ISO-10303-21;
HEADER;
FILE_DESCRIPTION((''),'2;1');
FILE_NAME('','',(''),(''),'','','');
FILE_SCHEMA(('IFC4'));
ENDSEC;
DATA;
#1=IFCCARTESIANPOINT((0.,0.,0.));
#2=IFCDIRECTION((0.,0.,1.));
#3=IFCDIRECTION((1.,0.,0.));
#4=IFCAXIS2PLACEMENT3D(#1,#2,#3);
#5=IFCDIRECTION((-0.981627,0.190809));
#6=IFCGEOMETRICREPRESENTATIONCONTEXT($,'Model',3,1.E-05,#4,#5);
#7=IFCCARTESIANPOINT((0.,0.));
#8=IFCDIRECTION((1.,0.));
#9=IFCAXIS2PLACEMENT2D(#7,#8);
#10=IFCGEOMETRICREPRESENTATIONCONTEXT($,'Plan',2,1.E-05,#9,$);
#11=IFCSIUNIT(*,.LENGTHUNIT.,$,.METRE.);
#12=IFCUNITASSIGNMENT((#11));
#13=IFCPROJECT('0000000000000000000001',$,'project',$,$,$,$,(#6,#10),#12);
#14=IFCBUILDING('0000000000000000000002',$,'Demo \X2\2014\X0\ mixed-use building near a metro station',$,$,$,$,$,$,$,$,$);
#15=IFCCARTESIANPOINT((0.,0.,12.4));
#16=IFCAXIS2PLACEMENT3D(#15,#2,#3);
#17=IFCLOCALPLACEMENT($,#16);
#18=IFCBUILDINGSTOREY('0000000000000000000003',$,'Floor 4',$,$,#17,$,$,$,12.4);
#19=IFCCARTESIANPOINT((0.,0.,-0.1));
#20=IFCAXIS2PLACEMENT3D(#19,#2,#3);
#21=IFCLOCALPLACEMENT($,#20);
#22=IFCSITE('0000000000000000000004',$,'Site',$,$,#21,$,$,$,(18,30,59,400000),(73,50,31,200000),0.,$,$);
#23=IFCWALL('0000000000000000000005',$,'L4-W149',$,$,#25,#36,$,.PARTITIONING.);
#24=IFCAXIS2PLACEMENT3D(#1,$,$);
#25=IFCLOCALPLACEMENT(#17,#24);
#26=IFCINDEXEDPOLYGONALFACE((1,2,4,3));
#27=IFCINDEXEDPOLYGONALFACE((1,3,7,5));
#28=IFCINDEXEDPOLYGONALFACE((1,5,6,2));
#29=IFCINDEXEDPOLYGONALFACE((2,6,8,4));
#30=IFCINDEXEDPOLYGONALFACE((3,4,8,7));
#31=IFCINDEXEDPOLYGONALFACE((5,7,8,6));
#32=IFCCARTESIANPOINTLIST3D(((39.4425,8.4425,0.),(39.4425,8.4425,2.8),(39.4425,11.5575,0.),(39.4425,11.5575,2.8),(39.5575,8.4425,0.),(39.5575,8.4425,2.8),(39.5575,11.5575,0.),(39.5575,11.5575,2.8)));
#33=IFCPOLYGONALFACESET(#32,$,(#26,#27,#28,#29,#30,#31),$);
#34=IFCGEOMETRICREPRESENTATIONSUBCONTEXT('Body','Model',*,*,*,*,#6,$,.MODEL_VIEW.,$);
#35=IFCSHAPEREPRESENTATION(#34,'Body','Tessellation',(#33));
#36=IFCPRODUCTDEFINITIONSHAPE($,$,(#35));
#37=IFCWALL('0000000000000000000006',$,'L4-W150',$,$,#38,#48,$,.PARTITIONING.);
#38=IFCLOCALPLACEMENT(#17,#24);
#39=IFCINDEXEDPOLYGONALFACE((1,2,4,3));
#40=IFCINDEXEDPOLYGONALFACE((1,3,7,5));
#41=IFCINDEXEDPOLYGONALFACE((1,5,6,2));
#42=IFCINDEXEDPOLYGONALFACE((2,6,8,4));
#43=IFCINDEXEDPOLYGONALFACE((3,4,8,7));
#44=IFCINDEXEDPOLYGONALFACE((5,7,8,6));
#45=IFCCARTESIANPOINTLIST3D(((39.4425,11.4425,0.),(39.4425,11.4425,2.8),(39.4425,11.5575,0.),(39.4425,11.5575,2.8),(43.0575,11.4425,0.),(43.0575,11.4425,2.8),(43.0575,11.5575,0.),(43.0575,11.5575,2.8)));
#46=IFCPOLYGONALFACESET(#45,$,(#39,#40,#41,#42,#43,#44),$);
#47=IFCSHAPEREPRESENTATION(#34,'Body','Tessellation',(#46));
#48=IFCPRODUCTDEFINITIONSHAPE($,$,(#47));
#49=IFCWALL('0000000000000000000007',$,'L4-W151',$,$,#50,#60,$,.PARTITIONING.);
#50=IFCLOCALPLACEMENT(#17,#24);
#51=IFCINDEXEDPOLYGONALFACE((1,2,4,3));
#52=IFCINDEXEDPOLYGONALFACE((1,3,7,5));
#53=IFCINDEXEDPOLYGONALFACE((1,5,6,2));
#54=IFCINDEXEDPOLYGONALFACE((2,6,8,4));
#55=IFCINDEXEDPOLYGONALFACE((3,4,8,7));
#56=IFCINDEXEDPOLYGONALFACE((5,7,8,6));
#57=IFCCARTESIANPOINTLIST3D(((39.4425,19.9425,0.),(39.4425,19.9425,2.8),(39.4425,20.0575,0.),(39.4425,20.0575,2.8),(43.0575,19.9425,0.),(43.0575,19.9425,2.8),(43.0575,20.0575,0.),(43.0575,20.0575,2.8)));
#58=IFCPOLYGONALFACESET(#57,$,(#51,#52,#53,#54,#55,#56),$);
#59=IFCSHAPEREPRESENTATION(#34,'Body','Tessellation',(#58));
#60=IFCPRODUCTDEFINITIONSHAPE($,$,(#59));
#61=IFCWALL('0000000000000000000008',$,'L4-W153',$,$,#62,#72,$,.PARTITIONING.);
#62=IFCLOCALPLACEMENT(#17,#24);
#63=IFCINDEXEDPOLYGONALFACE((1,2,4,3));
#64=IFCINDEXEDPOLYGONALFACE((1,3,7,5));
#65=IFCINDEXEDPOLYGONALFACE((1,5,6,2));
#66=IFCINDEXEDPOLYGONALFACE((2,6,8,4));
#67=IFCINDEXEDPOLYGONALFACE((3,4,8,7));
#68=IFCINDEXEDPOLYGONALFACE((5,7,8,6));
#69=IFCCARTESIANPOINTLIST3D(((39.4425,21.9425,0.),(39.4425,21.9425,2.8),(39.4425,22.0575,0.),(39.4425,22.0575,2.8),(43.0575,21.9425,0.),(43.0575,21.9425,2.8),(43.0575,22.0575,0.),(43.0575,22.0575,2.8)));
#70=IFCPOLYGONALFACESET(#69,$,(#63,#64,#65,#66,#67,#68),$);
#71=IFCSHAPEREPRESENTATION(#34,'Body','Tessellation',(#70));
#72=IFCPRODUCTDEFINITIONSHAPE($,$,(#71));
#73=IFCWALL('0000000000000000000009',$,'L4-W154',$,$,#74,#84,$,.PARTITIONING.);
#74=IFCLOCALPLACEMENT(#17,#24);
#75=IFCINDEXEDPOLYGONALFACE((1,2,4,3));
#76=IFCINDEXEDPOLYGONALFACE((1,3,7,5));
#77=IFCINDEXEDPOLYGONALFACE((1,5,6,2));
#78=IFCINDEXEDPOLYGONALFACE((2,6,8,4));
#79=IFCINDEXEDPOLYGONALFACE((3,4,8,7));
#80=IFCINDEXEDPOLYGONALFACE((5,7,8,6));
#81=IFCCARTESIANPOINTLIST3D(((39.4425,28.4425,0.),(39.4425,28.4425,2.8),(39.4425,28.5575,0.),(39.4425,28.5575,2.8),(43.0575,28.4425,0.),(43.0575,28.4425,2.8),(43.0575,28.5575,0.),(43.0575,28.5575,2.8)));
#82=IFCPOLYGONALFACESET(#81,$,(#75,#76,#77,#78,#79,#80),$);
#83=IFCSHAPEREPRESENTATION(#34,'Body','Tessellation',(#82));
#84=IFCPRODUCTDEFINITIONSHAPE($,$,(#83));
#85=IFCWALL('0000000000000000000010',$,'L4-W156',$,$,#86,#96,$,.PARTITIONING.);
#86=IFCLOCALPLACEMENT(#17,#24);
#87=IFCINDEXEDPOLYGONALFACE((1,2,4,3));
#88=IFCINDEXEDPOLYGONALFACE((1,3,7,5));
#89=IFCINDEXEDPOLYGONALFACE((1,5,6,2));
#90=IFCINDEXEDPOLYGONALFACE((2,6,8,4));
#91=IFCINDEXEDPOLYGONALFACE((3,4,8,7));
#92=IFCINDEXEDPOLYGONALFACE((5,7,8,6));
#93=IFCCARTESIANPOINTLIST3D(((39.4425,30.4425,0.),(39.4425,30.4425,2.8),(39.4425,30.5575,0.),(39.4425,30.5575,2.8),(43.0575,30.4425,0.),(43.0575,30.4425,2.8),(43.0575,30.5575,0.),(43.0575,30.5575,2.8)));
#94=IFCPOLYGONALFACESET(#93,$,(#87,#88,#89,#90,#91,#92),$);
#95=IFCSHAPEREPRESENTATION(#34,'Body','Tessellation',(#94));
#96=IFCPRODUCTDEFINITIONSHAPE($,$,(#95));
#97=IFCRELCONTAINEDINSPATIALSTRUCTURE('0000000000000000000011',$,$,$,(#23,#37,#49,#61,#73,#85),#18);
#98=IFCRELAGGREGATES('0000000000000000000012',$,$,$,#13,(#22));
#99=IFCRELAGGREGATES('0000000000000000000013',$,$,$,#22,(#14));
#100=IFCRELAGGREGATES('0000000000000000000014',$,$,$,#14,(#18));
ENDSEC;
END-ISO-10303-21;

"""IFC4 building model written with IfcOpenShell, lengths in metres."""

from ifc_helpers import new_model, si_unit, direction, frame, origin_with_axes, origin_2d_with_axis, place, context, subcontext, project, spatial, line, indexed_curve, outline, extrude, element, save


model = new_model("IFC4")

# Units and contexts
model_context = context("Model", 3, precision=1e-05, world=origin_with_axes(), true_north=direction((-0.981627, 0.190809)))
plan_context = context("Plan", 2, precision=1e-05, world=origin_2d_with_axis())
body_context = subcontext(model_context, "Body", "Model", "MODEL_VIEW")
ifc_project = project(units=[si_unit("LENGTHUNIT", "METRE")], contexts=[model_context, plan_context])

# Site, building, storey
site_placement = place(None, frame((0.0, 0.0, -0.1), z_axis=(0.0, 0.0, 1.0), x_axis=(1.0, 0.0, 0.0)))
site = spatial("IfcSite", under=ifc_project, at=site_placement, Name="Site", RefLatitude=(18, 30, 59, 400000), RefLongitude=(73, 50, 31, 200000), RefElevation=0.0)
building = spatial("IfcBuilding", under=site, Name="Demo — mixed-use building near a metro station")
storey_placement = place(None, frame((0.0, 0.0, 12.4), z_axis=(0.0, 0.0, 1.0), x_axis=(1.0, 0.0, 0.0)))
storey = spatial("IfcBuildingStorey", under=building, at=storey_placement, Name="Floor 4", Elevation=12.4)

# Walls
wall_1_placement = place(storey_placement, frame((0.0, 0.0, -12.4), z_axis=(0.0, 0.0, 1.0), x_axis=(1.0, 0.0, 0.0)))
element("IfcWall", 1, at=wall_1_placement, inside=storey, Name="L4-W149", PredefinedType="PARTITIONING", context=body_context, shape_type="SweptSolid", body=[
    extrude(outline(indexed_curve([(39.5575, 11.5575), (39.5575, 8.4425), (39.4425, 8.4425), (39.4425, 11.5575)], segments=[line(1, 2, 3, 4, 1)])), frame((0.0, 0.0, 12.4), z_axis=(0.0, 0.0, 1.0), x_axis=(1.0, 0.0, 0.0)), (0.0, 0.0, 1.0), 2.8),
])
wall_2_placement = place(storey_placement, frame((0.0, 0.0, -12.4), z_axis=(0.0, 0.0, 1.0), x_axis=(1.0, 0.0, 0.0)))
element("IfcWall", 2, at=wall_2_placement, inside=storey, Name="L4-W150", PredefinedType="PARTITIONING", context=body_context, shape_type="SweptSolid", body=[
    extrude(outline(indexed_curve([(39.4425, 11.5575), (43.0575, 11.5575), (43.0575, 11.4425), (39.4425, 11.4425)], segments=[line(1, 2, 3, 4, 1)])), frame((0.0, 0.0, 12.4), z_axis=(0.0, 0.0, 1.0), x_axis=(1.0, 0.0, 0.0)), (0.0, 0.0, 1.0), 2.8),
])
wall_3_placement = place(storey_placement, frame((0.0, 0.0, -12.4), z_axis=(0.0, 0.0, 1.0), x_axis=(1.0, 0.0, 0.0)))
element("IfcWall", 3, at=wall_3_placement, inside=storey, Name="L4-W151", PredefinedType="PARTITIONING", context=body_context, shape_type="SweptSolid", body=[
    extrude(outline(indexed_curve([(43.0575, 19.9425), (39.4425, 19.9425), (39.4425, 20.0575), (43.0575, 20.0575)], segments=[line(1, 2, 3, 4, 1)])), frame((0.0, 0.0, 12.4), z_axis=(0.0, 0.0, 1.0), x_axis=(1.0, 0.0, 0.0)), (0.0, 0.0, 1.0), 2.8),
])

# Walls
wall_4_placement = place(storey_placement, frame((0.0, 0.0, -12.4), z_axis=(0.0, 0.0, 1.0), x_axis=(1.0, 0.0, 0.0)))
element("IfcWall", 4, at=wall_4_placement, inside=storey, Name="L4-W153", PredefinedType="PARTITIONING", context=body_context, shape_type="SweptSolid", body=[
    extrude(outline(indexed_curve([(43.0575, 21.9425), (39.4425, 21.9425), (39.4425, 22.0575), (43.0575, 22.0575)], segments=[line(1, 2, 3, 4, 1)])), frame((0.0, 0.0, 12.4), z_axis=(0.0, 0.0, 1.0), x_axis=(1.0, 0.0, 0.0)), (0.0, 0.0, 1.0), 2.8),
])
wall_5_placement = place(storey_placement, frame((0.0, 0.0, -12.4), z_axis=(0.0, 0.0, 1.0), x_axis=(1.0, 0.0, 0.0)))
element("IfcWall", 5, at=wall_5_placement, inside=storey, Name="L4-W154", PredefinedType="PARTITIONING", context=body_context, shape_type="SweptSolid", body=[
    extrude(outline(indexed_curve([(43.0575, 28.4425), (39.4425, 28.4425), (39.4425, 28.5575), (43.0575, 28.5575)], segments=[line(1, 2, 3, 4, 1)])), frame((0.0, 0.0, 12.4), z_axis=(0.0, 0.0, 1.0), x_axis=(1.0, 0.0, 0.0)), (0.0, 0.0, 1.0), 2.8),
])

# Wall
wall_6_placement = place(storey_placement, frame((0.0, 0.0, -12.4), z_axis=(0.0, 0.0, 1.0), x_axis=(1.0, 0.0, 0.0)))
element("IfcWall", 6, at=wall_6_placement, inside=storey, Name="L4-W156", PredefinedType="PARTITIONING", context=body_context, shape_type="SweptSolid", body=[
    extrude(outline(indexed_curve([(43.0575, 30.4425), (39.4425, 30.4425), (39.4425, 30.5575), (43.0575, 30.5575)], segments=[line(1, 2, 3, 4, 1)])), frame((0.0, 0.0, 12.4), z_axis=(0.0, 0.0, 1.0), x_axis=(1.0, 0.0, 0.0)), (0.0, 0.0, 1.0), 2.8),
])

save(model, "model.ifc")
